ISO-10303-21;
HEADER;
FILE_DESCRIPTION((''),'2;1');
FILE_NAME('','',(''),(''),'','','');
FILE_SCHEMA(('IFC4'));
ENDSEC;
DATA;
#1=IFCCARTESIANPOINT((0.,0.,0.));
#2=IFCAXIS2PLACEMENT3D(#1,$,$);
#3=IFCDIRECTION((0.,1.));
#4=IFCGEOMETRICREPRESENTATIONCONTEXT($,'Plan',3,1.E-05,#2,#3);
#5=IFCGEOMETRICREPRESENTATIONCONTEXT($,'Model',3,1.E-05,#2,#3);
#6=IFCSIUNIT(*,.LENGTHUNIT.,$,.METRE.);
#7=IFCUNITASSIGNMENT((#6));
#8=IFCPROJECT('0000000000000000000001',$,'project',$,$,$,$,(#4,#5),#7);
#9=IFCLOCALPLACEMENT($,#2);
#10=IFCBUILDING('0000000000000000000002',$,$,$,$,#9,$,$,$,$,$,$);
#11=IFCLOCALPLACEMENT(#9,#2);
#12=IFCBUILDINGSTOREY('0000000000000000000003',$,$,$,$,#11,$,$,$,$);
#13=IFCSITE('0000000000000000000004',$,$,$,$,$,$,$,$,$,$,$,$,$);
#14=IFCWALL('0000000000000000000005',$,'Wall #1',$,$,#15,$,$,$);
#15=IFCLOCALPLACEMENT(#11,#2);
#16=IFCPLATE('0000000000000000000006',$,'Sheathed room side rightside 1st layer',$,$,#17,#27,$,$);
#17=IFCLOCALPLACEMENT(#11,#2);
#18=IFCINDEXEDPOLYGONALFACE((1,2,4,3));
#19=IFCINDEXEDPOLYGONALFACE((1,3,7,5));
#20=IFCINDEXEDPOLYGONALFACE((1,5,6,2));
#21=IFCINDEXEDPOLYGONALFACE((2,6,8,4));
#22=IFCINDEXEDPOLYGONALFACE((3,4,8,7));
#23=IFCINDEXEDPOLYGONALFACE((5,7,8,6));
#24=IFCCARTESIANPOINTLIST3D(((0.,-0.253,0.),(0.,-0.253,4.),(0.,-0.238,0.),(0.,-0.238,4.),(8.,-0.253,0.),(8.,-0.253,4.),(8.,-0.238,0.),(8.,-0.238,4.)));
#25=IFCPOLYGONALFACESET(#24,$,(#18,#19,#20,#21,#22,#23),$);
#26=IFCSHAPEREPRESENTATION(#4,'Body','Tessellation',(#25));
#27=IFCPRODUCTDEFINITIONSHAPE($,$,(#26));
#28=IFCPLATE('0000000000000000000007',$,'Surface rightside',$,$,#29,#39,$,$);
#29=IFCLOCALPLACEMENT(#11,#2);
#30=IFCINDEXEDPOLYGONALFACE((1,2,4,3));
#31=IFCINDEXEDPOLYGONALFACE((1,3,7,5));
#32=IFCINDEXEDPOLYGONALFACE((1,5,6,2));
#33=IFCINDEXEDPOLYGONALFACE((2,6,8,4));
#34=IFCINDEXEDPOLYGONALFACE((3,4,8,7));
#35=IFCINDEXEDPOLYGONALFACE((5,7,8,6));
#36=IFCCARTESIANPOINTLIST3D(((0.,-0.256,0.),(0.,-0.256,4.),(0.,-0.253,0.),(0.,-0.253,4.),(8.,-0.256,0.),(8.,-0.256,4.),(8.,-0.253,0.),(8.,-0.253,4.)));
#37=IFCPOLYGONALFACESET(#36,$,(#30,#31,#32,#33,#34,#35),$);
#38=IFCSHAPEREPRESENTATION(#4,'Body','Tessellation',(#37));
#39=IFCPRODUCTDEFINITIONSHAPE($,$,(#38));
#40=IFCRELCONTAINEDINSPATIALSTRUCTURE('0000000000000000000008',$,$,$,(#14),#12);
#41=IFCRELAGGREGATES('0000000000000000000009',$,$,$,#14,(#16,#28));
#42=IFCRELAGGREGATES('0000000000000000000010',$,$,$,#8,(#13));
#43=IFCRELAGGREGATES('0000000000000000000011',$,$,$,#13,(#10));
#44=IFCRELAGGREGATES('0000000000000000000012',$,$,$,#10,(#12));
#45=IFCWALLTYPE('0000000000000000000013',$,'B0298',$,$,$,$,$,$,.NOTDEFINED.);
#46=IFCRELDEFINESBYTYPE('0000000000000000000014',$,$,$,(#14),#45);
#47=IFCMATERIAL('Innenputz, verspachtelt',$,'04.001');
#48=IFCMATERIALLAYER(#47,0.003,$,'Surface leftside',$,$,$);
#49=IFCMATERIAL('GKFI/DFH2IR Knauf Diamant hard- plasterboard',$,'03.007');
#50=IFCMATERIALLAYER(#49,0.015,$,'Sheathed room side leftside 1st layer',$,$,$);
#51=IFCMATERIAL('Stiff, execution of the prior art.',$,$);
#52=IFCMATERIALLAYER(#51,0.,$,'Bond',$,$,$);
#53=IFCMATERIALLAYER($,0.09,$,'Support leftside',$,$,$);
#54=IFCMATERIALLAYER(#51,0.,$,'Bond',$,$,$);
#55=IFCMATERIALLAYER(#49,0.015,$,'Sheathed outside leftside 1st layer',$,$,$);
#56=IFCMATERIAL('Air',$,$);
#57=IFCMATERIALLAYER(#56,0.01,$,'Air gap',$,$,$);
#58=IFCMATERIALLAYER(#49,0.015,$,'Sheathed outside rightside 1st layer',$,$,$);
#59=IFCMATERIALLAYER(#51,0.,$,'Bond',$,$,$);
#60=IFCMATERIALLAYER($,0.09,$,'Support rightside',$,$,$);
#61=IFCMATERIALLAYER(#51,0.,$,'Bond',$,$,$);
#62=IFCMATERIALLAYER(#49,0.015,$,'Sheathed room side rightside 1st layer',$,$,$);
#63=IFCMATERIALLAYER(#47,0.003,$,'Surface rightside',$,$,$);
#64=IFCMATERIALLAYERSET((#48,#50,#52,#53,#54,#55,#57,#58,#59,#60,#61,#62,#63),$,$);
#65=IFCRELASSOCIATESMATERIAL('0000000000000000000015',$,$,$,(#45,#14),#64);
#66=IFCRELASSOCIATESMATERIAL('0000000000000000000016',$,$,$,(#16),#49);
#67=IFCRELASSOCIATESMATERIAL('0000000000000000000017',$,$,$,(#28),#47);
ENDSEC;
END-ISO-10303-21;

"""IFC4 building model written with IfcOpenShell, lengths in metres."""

from ifc_helpers import new_model, si_unit, direction, frame, frame_2d, origin, place, context, project, spatial, rectangle, extrude, material, layer, layer_set, type_object, element, aggregate, save


model = new_model("IFC4")

# Units and contexts
plan_context = context("Plan", 3, precision=1e-05, world=origin(), true_north=direction((0.0, 1.0)))
model_context = context("Model", 3, precision=1e-05, world=origin(), true_north=direction((0.0, 1.0)))
ifc_project = project(units=[si_unit("LENGTHUNIT", "METRE")], contexts=[plan_context, model_context])

# Site, building, storey
site = spatial("IfcSite", under=ifc_project)
building_placement = place(None, origin())
building = spatial("IfcBuilding", under=site, at=building_placement)
storey_placement = place(building_placement, origin())
storey = spatial("IfcBuildingStorey", under=building, at=storey_placement)

# Wall, plates
ifc_material_1 = material(Name="Innenputz, verspachtelt", Category="04.001")
ifc_layer_1 = layer(ifc_material_1, 0.003, Name="Surface leftside")
ifc_material_2 = material(Name="GKFI/DFH2IR Knauf Diamant hard- plasterboard", Category="03.007")
ifc_layer_2 = layer(ifc_material_2, 0.015, Name="Sheathed room side leftside 1st layer")
ifc_material_3 = material(Name="Stiff, execution of the prior art.")
ifc_layer_3 = layer(ifc_material_3, 0.0, Name="Bond")
ifc_layer_4 = layer(None, 0.09, Name="Support leftside")
ifc_layer_5 = layer(ifc_material_3, 0.0, Name="Bond")
ifc_layer_6 = layer(ifc_material_2, 0.015, Name="Sheathed outside leftside 1st layer")
ifc_material_4 = material(Name="Air")
ifc_layer_7 = layer(ifc_material_4, 0.01, Name="Air gap")
ifc_layer_8 = layer(ifc_material_2, 0.015, Name="Sheathed outside rightside 1st layer")
ifc_layer_9 = layer(ifc_material_3, 0.0, Name="Bond")
ifc_layer_10 = layer(None, 0.09, Name="Support rightside")
ifc_layer_11 = layer(ifc_material_3, 0.0, Name="Bond")
ifc_layer_12 = layer(ifc_material_2, 0.015, Name="Sheathed room side rightside 1st layer")
ifc_layer_13 = layer(ifc_material_1, 0.003, Name="Surface rightside")
ifc_layer_set = layer_set([ifc_layer_1, ifc_layer_2, ifc_layer_3, ifc_layer_4, ifc_layer_5, ifc_layer_6, ifc_layer_7, ifc_layer_8, ifc_layer_9, ifc_layer_10, ifc_layer_11, ifc_layer_12, ifc_layer_13])
wall_type = type_object("IfcWallType", Name="B0298", PredefinedType="NOTDEFINED", material=ifc_layer_set)
wall_placement = place(None, frame((0.0, 0.0, 0.0), z_axis=(0.0, -1.0, 0.0), x_axis=(1.0, 0.0, 0.0)))
wall = element("IfcWall", 1, at=wall_placement, inside=storey, type_object=wall_type, material=ifc_layer_set, Name="Wall #1")
plate_1_placement = place(wall_placement, origin())
plate_1 = element("IfcPlate", 2, at=plate_1_placement, material=ifc_material_2, Name="Sheathed room side rightside 1st layer", context=plan_context, shape_type="SweptSolid", body=[
    extrude(rectangle(XDim=8.0, YDim=4.0, at=frame_2d((4.0, 2.0), x_axis=(1.0, 0.0))), frame((0.0, 0.0, 0.238), z_axis=(0.0, 0.0, 1.0), x_axis=(1.0, 0.0, 0.0)), (0.0, 0.0, 1.0), 0.015),
])
plate_2_placement = place(wall_placement, origin())
plate_2 = element("IfcPlate", 3, at=plate_2_placement, material=ifc_material_1, Name="Surface rightside", context=plan_context, shape_type="SweptSolid", body=[
    extrude(rectangle(XDim=8.0, YDim=4.0, at=frame_2d((4.0, 2.0), x_axis=(1.0, 0.0))), frame((0.0, 0.0, 0.253), z_axis=(0.0, 0.0, 1.0), x_axis=(1.0, 0.0, 0.0)), (0.0, 0.0, 1.0), 0.003),
])
aggregate(wall, [plate_1, plate_2])

save(model, "model.ifc")
